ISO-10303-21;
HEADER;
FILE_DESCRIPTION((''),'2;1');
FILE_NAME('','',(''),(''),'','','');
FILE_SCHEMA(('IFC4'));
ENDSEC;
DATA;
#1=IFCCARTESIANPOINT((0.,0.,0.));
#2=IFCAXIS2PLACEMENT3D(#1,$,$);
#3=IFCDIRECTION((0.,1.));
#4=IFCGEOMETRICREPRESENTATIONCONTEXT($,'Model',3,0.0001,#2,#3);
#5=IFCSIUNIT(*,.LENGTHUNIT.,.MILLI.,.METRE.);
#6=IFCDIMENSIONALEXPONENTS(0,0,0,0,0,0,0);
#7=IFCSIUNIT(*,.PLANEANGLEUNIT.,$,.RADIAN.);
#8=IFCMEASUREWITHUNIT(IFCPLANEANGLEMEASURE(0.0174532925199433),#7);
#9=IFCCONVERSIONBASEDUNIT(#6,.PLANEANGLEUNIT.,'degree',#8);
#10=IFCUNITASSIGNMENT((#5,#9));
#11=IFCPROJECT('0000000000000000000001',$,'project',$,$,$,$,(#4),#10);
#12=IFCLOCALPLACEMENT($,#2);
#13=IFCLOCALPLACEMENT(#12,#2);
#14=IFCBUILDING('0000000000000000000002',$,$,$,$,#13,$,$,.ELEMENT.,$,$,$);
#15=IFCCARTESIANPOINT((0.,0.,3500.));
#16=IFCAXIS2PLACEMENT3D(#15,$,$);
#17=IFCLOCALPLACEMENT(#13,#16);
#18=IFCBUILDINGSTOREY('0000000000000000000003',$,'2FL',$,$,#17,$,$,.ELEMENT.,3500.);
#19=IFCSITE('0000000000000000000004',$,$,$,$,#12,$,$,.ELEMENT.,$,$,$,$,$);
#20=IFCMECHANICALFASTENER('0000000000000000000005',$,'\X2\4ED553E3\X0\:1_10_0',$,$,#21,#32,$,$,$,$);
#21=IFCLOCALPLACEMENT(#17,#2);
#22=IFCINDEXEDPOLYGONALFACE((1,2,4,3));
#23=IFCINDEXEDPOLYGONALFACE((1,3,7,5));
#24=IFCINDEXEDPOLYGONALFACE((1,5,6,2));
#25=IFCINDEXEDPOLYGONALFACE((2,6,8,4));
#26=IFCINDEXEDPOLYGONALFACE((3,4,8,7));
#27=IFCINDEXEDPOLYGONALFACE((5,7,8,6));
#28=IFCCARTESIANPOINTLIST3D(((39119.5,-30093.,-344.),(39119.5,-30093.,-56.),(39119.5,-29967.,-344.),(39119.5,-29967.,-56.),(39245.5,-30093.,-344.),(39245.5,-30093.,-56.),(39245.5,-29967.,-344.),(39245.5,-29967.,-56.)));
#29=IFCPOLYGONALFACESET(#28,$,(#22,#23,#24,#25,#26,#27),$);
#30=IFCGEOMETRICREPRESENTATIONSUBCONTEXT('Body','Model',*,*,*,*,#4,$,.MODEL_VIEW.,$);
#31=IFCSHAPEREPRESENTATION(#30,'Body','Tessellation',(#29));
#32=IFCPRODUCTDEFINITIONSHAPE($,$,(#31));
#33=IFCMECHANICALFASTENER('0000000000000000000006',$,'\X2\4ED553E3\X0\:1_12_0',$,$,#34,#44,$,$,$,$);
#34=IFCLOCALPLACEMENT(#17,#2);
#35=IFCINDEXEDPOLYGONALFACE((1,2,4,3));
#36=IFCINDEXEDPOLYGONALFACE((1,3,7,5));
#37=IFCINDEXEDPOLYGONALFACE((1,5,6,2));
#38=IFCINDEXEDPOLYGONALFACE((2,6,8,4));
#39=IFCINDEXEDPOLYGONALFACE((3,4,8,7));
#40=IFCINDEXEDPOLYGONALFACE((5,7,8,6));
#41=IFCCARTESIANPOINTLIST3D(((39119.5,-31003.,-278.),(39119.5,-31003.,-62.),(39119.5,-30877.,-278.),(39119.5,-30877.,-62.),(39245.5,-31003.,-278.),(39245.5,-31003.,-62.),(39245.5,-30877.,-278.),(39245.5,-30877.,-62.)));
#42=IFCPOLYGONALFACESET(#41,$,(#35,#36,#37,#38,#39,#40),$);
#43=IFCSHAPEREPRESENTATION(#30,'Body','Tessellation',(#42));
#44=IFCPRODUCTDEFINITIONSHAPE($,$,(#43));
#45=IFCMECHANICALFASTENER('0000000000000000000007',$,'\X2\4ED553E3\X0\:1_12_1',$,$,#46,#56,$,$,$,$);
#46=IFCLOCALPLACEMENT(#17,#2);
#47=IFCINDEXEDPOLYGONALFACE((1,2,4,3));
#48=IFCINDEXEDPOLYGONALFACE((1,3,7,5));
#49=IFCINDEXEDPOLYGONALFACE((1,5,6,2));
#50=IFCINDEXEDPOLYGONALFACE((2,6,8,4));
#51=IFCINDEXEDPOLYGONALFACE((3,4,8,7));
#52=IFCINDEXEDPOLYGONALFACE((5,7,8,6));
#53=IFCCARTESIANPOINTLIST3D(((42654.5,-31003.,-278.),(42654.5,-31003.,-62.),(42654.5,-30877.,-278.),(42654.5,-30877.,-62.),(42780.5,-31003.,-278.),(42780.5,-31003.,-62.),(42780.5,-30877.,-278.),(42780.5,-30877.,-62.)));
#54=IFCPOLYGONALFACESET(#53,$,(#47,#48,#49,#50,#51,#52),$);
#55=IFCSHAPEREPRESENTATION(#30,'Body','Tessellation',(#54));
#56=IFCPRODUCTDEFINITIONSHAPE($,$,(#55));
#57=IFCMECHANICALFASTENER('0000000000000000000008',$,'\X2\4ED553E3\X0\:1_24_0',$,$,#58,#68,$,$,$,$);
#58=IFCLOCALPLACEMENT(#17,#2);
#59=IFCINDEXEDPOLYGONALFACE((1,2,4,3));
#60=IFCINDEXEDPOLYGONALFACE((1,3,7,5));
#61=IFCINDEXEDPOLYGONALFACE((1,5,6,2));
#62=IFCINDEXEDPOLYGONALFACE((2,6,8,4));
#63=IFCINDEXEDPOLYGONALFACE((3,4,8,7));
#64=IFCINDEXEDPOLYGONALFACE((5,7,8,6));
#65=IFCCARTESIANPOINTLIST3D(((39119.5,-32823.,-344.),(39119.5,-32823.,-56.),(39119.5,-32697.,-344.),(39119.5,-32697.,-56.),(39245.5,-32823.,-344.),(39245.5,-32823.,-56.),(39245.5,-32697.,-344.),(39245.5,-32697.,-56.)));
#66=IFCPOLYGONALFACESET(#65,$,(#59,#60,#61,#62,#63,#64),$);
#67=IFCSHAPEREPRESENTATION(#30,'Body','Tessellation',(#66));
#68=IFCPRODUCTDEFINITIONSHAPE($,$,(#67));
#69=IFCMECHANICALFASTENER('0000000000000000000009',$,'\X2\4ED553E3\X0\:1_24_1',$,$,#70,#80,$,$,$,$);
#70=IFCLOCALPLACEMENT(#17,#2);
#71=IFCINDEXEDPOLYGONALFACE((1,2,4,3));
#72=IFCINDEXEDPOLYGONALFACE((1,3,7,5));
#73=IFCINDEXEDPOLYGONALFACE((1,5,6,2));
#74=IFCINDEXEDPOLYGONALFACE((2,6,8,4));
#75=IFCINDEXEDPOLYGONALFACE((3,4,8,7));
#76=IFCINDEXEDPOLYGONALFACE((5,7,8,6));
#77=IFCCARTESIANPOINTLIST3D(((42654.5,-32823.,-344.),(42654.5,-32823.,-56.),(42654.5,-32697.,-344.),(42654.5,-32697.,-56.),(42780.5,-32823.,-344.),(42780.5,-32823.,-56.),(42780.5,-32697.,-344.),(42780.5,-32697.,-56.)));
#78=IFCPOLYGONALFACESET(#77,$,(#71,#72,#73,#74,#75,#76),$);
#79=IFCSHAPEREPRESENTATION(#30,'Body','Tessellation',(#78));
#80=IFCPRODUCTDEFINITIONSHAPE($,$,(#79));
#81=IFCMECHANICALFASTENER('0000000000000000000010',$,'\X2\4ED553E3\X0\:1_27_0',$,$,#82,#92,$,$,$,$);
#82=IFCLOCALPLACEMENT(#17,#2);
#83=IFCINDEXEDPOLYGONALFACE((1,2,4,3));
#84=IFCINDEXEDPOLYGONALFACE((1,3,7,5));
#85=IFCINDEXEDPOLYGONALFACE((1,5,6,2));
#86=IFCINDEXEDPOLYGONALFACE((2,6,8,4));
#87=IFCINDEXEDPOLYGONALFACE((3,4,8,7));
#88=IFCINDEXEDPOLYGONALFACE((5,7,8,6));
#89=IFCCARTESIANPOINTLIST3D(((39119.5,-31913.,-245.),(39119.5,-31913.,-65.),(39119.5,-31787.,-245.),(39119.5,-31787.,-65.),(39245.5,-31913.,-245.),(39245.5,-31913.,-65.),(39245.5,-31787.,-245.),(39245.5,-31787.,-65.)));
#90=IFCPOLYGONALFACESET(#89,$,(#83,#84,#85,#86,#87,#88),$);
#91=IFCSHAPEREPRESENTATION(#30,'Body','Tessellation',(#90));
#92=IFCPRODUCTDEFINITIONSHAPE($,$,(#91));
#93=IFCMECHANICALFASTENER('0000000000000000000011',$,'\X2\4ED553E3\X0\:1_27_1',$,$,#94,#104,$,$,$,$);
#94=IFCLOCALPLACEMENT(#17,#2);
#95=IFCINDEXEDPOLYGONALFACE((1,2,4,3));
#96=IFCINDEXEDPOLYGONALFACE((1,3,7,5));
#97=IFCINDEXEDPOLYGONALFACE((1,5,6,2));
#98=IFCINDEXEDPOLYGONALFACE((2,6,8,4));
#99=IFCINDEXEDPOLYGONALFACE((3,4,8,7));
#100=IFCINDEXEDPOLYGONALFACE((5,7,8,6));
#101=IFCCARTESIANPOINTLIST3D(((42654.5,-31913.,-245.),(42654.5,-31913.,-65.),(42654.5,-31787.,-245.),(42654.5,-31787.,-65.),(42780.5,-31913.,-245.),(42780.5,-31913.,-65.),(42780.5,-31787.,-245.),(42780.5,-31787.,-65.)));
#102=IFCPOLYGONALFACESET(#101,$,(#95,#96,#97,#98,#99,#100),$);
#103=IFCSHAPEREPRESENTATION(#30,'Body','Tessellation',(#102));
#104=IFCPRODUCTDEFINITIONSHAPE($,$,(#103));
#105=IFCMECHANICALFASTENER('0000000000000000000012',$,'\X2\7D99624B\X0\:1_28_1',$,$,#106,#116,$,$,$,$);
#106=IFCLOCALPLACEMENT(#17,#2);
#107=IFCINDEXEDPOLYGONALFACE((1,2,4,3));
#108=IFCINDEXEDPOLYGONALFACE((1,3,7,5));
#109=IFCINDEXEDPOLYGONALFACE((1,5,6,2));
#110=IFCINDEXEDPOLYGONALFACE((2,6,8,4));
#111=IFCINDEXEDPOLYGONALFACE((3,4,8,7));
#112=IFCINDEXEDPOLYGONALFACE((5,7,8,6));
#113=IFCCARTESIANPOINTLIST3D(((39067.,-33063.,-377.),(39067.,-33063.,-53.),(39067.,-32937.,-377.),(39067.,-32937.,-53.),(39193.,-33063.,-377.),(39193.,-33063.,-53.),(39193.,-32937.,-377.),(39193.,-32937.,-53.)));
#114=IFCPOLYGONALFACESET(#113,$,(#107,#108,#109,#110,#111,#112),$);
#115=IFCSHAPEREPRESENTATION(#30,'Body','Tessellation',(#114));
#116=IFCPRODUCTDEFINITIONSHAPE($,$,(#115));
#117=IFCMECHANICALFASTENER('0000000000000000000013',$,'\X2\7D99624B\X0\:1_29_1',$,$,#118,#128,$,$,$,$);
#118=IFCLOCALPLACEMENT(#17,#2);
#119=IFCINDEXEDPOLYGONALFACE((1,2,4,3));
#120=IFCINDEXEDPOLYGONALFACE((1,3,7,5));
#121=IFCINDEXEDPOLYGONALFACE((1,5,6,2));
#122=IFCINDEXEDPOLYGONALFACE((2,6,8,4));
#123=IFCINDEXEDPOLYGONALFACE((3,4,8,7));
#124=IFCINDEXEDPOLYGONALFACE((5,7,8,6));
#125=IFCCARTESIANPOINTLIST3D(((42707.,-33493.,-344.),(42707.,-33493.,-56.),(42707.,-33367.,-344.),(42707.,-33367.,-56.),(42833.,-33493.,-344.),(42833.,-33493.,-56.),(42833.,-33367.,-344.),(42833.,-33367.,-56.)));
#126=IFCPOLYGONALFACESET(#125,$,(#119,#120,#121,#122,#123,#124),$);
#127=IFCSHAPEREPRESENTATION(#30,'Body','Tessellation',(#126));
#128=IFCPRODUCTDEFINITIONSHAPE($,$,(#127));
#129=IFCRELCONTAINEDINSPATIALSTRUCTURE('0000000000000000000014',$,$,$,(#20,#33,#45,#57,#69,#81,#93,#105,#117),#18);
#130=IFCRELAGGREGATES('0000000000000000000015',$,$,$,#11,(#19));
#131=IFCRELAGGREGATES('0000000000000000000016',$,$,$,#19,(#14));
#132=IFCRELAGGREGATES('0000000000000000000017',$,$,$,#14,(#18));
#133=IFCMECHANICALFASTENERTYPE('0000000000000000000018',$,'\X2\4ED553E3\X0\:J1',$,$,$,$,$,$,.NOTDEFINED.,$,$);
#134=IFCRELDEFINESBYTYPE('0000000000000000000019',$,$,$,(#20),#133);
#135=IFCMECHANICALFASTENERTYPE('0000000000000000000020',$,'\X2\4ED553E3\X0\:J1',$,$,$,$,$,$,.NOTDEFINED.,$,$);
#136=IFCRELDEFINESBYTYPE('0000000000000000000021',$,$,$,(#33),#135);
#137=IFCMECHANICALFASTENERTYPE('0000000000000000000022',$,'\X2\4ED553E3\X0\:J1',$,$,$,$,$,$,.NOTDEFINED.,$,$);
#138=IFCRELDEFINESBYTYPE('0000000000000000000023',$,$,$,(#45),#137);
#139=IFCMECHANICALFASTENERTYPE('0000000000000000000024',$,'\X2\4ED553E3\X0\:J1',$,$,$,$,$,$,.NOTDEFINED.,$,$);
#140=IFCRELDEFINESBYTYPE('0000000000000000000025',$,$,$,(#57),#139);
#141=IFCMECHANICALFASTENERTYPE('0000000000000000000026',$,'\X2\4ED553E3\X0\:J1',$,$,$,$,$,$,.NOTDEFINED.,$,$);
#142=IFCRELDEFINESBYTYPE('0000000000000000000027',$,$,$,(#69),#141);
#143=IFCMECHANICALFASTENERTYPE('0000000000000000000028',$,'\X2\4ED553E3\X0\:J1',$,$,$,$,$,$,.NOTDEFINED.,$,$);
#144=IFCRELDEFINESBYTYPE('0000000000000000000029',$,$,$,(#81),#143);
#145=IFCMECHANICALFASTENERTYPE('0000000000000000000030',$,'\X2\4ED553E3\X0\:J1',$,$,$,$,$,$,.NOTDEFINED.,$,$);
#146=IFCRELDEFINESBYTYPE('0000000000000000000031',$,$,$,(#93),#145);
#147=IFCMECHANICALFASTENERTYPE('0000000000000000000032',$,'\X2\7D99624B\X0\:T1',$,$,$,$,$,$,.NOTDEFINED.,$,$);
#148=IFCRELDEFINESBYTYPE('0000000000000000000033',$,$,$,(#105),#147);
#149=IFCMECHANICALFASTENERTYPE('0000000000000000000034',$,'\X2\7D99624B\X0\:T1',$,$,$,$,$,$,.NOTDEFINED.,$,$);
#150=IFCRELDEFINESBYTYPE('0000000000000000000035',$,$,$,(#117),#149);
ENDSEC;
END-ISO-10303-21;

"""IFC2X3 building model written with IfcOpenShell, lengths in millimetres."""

from ifc_helpers import new_model, entity, si_unit, converted_unit, direction, frame, origin, origin_with_axes, origin_2d, place, context, subcontext, project, spatial, rectangle, extrude, type_object, element, save


model = new_model("IFC2X3")

# Units and contexts
model_context = context("Model", 3, precision=0.0001, world=origin(), true_north=direction((0.0, 1.0)))
body_context = subcontext(model_context, "Body", "Model", "MODEL_VIEW")
ifc_project = project(units=[si_unit("LENGTHUNIT", "METRE", prefix="MILLI"), converted_unit("PLANEANGLEUNIT", "degree", entity("IfcPlaneAngleMeasure", 0.0174532925199433), si_unit("PLANEANGLEUNIT", "RADIAN"), dimensions=[0, 0, 0, 0, 0, 0, 0])], contexts=[model_context])

# Site, building, storey
site_placement = place(None, origin())
site = spatial("IfcSite", under=ifc_project, at=site_placement, CompositionType="ELEMENT")
building_placement = place(site_placement, origin())
building = spatial("IfcBuilding", under=site, at=building_placement, CompositionType="ELEMENT")
storey_placement = place(building_placement, frame((0.0, 0.0, 3500.0)))
storey = spatial("IfcBuildingStorey", under=building, at=storey_placement, Name="2FL", CompositionType="ELEMENT", Elevation=3500.0)

# Mechanical fasteners
mechanical_fastener_type_1 = type_object("IfcMechanicalFastenerType", Name="仕口:J1")
mechanical_fastener_1_placement = place(storey_placement, frame((39182.5, -30030.0, -344.0)))
element("IfcMechanicalFastener", 1, at=mechanical_fastener_1_placement, inside=storey, type_object=mechanical_fastener_type_1, Name="仕口:1_10_0", context=body_context, shape_type="SweptSolid", body=[
    extrude(rectangle(XDim=126.0, YDim=126.0, at=origin_2d()), origin_with_axes(), (0.0, 0.0, 1.0), 288.0),
])
mechanical_fastener_type_2 = type_object("IfcMechanicalFastenerType", Name="仕口:J1")
mechanical_fastener_2_placement = place(storey_placement, frame((39182.5, -30940.0, -278.0)))
element("IfcMechanicalFastener", 2, at=mechanical_fastener_2_placement, inside=storey, type_object=mechanical_fastener_type_2, Name="仕口:1_12_0", context=body_context, shape_type="SweptSolid", body=[
    extrude(rectangle(XDim=126.0, YDim=126.0, at=origin_2d()), origin_with_axes(), (0.0, 0.0, 1.0), 216.0),
])
mechanical_fastener_type_3 = type_object("IfcMechanicalFastenerType", Name="仕口:J1")
mechanical_fastener_3_placement = place(storey_placement, frame((42717.5, -30940.0, -278.0)))
element("IfcMechanicalFastener", 3, at=mechanical_fastener_3_placement, inside=storey, type_object=mechanical_fastener_type_3, Name="仕口:1_12_1", context=body_context, shape_type="SweptSolid", body=[
    extrude(rectangle(XDim=126.0, YDim=126.0, at=origin_2d()), origin_with_axes(), (0.0, 0.0, 1.0), 216.0),
])
mechanical_fastener_type_4 = type_object("IfcMechanicalFastenerType", Name="仕口:J1")
mechanical_fastener_4_placement = place(storey_placement, frame((39182.5, -32760.0, -344.0)))
element("IfcMechanicalFastener", 4, at=mechanical_fastener_4_placement, inside=storey, type_object=mechanical_fastener_type_4, Name="仕口:1_24_0", context=body_context, shape_type="SweptSolid", body=[
    extrude(rectangle(XDim=126.0, YDim=126.0, at=origin_2d()), origin_with_axes(), (0.0, 0.0, 1.0), 288.0),
])
mechanical_fastener_type_5 = type_object("IfcMechanicalFastenerType", Name="仕口:J1")
mechanical_fastener_5_placement = place(storey_placement, frame((42717.5, -32760.0, -344.0)))
element("IfcMechanicalFastener", 5, at=mechanical_fastener_5_placement, inside=storey, type_object=mechanical_fastener_type_5, Name="仕口:1_24_1", context=body_context, shape_type="SweptSolid", body=[
    extrude(rectangle(XDim=126.0, YDim=126.0, at=origin_2d()), origin_with_axes(), (0.0, 0.0, 1.0), 288.0),
])
mechanical_fastener_type_6 = type_object("IfcMechanicalFastenerType", Name="仕口:J1")
mechanical_fastener_6_placement = place(storey_placement, frame((39182.5, -31850.0, -245.0)))
element("IfcMechanicalFastener", 6, at=mechanical_fastener_6_placement, inside=storey, type_object=mechanical_fastener_type_6, Name="仕口:1_27_0", context=body_context, shape_type="SweptSolid", body=[
    extrude(rectangle(XDim=126.0, YDim=126.0, at=origin_2d()), origin_with_axes(), (0.0, 0.0, 1.0), 180.0),
])
mechanical_fastener_type_7 = type_object("IfcMechanicalFastenerType", Name="仕口:J1")
mechanical_fastener_7_placement = place(storey_placement, frame((42717.5, -31850.0, -245.0)))
element("IfcMechanicalFastener", 7, at=mechanical_fastener_7_placement, inside=storey, type_object=mechanical_fastener_type_7, Name="仕口:1_27_1", context=body_context, shape_type="SweptSolid", body=[
    extrude(rectangle(XDim=126.0, YDim=126.0, at=origin_2d()), origin_with_axes(), (0.0, 0.0, 1.0), 180.0),
])
mechanical_fastener_type_8 = type_object("IfcMechanicalFastenerType", Name="継手:T1")
mechanical_fastener_8_placement = place(storey_placement, frame((39130.0, -33000.0, -377.0)))
element("IfcMechanicalFastener", 8, at=mechanical_fastener_8_placement, inside=storey, type_object=mechanical_fastener_type_8, Name="継手:1_28_1", context=body_context, shape_type="SweptSolid", body=[
    extrude(rectangle(XDim=126.0, YDim=126.0, at=origin_2d()), origin_with_axes(), (0.0, 0.0, 1.0), 324.0),
])
mechanical_fastener_type_9 = type_object("IfcMechanicalFastenerType", Name="継手:T1")
mechanical_fastener_9_placement = place(storey_placement, frame((42770.0, -33430.0, -344.0)))
element("IfcMechanicalFastener", 9, at=mechanical_fastener_9_placement, inside=storey, type_object=mechanical_fastener_type_9, Name="継手:1_29_1", context=body_context, shape_type="SweptSolid", body=[
    extrude(rectangle(XDim=126.0, YDim=126.0, at=origin_2d()), origin_with_axes(), (0.0, 0.0, 1.0), 288.0),
])

save(model, "model.ifc")
